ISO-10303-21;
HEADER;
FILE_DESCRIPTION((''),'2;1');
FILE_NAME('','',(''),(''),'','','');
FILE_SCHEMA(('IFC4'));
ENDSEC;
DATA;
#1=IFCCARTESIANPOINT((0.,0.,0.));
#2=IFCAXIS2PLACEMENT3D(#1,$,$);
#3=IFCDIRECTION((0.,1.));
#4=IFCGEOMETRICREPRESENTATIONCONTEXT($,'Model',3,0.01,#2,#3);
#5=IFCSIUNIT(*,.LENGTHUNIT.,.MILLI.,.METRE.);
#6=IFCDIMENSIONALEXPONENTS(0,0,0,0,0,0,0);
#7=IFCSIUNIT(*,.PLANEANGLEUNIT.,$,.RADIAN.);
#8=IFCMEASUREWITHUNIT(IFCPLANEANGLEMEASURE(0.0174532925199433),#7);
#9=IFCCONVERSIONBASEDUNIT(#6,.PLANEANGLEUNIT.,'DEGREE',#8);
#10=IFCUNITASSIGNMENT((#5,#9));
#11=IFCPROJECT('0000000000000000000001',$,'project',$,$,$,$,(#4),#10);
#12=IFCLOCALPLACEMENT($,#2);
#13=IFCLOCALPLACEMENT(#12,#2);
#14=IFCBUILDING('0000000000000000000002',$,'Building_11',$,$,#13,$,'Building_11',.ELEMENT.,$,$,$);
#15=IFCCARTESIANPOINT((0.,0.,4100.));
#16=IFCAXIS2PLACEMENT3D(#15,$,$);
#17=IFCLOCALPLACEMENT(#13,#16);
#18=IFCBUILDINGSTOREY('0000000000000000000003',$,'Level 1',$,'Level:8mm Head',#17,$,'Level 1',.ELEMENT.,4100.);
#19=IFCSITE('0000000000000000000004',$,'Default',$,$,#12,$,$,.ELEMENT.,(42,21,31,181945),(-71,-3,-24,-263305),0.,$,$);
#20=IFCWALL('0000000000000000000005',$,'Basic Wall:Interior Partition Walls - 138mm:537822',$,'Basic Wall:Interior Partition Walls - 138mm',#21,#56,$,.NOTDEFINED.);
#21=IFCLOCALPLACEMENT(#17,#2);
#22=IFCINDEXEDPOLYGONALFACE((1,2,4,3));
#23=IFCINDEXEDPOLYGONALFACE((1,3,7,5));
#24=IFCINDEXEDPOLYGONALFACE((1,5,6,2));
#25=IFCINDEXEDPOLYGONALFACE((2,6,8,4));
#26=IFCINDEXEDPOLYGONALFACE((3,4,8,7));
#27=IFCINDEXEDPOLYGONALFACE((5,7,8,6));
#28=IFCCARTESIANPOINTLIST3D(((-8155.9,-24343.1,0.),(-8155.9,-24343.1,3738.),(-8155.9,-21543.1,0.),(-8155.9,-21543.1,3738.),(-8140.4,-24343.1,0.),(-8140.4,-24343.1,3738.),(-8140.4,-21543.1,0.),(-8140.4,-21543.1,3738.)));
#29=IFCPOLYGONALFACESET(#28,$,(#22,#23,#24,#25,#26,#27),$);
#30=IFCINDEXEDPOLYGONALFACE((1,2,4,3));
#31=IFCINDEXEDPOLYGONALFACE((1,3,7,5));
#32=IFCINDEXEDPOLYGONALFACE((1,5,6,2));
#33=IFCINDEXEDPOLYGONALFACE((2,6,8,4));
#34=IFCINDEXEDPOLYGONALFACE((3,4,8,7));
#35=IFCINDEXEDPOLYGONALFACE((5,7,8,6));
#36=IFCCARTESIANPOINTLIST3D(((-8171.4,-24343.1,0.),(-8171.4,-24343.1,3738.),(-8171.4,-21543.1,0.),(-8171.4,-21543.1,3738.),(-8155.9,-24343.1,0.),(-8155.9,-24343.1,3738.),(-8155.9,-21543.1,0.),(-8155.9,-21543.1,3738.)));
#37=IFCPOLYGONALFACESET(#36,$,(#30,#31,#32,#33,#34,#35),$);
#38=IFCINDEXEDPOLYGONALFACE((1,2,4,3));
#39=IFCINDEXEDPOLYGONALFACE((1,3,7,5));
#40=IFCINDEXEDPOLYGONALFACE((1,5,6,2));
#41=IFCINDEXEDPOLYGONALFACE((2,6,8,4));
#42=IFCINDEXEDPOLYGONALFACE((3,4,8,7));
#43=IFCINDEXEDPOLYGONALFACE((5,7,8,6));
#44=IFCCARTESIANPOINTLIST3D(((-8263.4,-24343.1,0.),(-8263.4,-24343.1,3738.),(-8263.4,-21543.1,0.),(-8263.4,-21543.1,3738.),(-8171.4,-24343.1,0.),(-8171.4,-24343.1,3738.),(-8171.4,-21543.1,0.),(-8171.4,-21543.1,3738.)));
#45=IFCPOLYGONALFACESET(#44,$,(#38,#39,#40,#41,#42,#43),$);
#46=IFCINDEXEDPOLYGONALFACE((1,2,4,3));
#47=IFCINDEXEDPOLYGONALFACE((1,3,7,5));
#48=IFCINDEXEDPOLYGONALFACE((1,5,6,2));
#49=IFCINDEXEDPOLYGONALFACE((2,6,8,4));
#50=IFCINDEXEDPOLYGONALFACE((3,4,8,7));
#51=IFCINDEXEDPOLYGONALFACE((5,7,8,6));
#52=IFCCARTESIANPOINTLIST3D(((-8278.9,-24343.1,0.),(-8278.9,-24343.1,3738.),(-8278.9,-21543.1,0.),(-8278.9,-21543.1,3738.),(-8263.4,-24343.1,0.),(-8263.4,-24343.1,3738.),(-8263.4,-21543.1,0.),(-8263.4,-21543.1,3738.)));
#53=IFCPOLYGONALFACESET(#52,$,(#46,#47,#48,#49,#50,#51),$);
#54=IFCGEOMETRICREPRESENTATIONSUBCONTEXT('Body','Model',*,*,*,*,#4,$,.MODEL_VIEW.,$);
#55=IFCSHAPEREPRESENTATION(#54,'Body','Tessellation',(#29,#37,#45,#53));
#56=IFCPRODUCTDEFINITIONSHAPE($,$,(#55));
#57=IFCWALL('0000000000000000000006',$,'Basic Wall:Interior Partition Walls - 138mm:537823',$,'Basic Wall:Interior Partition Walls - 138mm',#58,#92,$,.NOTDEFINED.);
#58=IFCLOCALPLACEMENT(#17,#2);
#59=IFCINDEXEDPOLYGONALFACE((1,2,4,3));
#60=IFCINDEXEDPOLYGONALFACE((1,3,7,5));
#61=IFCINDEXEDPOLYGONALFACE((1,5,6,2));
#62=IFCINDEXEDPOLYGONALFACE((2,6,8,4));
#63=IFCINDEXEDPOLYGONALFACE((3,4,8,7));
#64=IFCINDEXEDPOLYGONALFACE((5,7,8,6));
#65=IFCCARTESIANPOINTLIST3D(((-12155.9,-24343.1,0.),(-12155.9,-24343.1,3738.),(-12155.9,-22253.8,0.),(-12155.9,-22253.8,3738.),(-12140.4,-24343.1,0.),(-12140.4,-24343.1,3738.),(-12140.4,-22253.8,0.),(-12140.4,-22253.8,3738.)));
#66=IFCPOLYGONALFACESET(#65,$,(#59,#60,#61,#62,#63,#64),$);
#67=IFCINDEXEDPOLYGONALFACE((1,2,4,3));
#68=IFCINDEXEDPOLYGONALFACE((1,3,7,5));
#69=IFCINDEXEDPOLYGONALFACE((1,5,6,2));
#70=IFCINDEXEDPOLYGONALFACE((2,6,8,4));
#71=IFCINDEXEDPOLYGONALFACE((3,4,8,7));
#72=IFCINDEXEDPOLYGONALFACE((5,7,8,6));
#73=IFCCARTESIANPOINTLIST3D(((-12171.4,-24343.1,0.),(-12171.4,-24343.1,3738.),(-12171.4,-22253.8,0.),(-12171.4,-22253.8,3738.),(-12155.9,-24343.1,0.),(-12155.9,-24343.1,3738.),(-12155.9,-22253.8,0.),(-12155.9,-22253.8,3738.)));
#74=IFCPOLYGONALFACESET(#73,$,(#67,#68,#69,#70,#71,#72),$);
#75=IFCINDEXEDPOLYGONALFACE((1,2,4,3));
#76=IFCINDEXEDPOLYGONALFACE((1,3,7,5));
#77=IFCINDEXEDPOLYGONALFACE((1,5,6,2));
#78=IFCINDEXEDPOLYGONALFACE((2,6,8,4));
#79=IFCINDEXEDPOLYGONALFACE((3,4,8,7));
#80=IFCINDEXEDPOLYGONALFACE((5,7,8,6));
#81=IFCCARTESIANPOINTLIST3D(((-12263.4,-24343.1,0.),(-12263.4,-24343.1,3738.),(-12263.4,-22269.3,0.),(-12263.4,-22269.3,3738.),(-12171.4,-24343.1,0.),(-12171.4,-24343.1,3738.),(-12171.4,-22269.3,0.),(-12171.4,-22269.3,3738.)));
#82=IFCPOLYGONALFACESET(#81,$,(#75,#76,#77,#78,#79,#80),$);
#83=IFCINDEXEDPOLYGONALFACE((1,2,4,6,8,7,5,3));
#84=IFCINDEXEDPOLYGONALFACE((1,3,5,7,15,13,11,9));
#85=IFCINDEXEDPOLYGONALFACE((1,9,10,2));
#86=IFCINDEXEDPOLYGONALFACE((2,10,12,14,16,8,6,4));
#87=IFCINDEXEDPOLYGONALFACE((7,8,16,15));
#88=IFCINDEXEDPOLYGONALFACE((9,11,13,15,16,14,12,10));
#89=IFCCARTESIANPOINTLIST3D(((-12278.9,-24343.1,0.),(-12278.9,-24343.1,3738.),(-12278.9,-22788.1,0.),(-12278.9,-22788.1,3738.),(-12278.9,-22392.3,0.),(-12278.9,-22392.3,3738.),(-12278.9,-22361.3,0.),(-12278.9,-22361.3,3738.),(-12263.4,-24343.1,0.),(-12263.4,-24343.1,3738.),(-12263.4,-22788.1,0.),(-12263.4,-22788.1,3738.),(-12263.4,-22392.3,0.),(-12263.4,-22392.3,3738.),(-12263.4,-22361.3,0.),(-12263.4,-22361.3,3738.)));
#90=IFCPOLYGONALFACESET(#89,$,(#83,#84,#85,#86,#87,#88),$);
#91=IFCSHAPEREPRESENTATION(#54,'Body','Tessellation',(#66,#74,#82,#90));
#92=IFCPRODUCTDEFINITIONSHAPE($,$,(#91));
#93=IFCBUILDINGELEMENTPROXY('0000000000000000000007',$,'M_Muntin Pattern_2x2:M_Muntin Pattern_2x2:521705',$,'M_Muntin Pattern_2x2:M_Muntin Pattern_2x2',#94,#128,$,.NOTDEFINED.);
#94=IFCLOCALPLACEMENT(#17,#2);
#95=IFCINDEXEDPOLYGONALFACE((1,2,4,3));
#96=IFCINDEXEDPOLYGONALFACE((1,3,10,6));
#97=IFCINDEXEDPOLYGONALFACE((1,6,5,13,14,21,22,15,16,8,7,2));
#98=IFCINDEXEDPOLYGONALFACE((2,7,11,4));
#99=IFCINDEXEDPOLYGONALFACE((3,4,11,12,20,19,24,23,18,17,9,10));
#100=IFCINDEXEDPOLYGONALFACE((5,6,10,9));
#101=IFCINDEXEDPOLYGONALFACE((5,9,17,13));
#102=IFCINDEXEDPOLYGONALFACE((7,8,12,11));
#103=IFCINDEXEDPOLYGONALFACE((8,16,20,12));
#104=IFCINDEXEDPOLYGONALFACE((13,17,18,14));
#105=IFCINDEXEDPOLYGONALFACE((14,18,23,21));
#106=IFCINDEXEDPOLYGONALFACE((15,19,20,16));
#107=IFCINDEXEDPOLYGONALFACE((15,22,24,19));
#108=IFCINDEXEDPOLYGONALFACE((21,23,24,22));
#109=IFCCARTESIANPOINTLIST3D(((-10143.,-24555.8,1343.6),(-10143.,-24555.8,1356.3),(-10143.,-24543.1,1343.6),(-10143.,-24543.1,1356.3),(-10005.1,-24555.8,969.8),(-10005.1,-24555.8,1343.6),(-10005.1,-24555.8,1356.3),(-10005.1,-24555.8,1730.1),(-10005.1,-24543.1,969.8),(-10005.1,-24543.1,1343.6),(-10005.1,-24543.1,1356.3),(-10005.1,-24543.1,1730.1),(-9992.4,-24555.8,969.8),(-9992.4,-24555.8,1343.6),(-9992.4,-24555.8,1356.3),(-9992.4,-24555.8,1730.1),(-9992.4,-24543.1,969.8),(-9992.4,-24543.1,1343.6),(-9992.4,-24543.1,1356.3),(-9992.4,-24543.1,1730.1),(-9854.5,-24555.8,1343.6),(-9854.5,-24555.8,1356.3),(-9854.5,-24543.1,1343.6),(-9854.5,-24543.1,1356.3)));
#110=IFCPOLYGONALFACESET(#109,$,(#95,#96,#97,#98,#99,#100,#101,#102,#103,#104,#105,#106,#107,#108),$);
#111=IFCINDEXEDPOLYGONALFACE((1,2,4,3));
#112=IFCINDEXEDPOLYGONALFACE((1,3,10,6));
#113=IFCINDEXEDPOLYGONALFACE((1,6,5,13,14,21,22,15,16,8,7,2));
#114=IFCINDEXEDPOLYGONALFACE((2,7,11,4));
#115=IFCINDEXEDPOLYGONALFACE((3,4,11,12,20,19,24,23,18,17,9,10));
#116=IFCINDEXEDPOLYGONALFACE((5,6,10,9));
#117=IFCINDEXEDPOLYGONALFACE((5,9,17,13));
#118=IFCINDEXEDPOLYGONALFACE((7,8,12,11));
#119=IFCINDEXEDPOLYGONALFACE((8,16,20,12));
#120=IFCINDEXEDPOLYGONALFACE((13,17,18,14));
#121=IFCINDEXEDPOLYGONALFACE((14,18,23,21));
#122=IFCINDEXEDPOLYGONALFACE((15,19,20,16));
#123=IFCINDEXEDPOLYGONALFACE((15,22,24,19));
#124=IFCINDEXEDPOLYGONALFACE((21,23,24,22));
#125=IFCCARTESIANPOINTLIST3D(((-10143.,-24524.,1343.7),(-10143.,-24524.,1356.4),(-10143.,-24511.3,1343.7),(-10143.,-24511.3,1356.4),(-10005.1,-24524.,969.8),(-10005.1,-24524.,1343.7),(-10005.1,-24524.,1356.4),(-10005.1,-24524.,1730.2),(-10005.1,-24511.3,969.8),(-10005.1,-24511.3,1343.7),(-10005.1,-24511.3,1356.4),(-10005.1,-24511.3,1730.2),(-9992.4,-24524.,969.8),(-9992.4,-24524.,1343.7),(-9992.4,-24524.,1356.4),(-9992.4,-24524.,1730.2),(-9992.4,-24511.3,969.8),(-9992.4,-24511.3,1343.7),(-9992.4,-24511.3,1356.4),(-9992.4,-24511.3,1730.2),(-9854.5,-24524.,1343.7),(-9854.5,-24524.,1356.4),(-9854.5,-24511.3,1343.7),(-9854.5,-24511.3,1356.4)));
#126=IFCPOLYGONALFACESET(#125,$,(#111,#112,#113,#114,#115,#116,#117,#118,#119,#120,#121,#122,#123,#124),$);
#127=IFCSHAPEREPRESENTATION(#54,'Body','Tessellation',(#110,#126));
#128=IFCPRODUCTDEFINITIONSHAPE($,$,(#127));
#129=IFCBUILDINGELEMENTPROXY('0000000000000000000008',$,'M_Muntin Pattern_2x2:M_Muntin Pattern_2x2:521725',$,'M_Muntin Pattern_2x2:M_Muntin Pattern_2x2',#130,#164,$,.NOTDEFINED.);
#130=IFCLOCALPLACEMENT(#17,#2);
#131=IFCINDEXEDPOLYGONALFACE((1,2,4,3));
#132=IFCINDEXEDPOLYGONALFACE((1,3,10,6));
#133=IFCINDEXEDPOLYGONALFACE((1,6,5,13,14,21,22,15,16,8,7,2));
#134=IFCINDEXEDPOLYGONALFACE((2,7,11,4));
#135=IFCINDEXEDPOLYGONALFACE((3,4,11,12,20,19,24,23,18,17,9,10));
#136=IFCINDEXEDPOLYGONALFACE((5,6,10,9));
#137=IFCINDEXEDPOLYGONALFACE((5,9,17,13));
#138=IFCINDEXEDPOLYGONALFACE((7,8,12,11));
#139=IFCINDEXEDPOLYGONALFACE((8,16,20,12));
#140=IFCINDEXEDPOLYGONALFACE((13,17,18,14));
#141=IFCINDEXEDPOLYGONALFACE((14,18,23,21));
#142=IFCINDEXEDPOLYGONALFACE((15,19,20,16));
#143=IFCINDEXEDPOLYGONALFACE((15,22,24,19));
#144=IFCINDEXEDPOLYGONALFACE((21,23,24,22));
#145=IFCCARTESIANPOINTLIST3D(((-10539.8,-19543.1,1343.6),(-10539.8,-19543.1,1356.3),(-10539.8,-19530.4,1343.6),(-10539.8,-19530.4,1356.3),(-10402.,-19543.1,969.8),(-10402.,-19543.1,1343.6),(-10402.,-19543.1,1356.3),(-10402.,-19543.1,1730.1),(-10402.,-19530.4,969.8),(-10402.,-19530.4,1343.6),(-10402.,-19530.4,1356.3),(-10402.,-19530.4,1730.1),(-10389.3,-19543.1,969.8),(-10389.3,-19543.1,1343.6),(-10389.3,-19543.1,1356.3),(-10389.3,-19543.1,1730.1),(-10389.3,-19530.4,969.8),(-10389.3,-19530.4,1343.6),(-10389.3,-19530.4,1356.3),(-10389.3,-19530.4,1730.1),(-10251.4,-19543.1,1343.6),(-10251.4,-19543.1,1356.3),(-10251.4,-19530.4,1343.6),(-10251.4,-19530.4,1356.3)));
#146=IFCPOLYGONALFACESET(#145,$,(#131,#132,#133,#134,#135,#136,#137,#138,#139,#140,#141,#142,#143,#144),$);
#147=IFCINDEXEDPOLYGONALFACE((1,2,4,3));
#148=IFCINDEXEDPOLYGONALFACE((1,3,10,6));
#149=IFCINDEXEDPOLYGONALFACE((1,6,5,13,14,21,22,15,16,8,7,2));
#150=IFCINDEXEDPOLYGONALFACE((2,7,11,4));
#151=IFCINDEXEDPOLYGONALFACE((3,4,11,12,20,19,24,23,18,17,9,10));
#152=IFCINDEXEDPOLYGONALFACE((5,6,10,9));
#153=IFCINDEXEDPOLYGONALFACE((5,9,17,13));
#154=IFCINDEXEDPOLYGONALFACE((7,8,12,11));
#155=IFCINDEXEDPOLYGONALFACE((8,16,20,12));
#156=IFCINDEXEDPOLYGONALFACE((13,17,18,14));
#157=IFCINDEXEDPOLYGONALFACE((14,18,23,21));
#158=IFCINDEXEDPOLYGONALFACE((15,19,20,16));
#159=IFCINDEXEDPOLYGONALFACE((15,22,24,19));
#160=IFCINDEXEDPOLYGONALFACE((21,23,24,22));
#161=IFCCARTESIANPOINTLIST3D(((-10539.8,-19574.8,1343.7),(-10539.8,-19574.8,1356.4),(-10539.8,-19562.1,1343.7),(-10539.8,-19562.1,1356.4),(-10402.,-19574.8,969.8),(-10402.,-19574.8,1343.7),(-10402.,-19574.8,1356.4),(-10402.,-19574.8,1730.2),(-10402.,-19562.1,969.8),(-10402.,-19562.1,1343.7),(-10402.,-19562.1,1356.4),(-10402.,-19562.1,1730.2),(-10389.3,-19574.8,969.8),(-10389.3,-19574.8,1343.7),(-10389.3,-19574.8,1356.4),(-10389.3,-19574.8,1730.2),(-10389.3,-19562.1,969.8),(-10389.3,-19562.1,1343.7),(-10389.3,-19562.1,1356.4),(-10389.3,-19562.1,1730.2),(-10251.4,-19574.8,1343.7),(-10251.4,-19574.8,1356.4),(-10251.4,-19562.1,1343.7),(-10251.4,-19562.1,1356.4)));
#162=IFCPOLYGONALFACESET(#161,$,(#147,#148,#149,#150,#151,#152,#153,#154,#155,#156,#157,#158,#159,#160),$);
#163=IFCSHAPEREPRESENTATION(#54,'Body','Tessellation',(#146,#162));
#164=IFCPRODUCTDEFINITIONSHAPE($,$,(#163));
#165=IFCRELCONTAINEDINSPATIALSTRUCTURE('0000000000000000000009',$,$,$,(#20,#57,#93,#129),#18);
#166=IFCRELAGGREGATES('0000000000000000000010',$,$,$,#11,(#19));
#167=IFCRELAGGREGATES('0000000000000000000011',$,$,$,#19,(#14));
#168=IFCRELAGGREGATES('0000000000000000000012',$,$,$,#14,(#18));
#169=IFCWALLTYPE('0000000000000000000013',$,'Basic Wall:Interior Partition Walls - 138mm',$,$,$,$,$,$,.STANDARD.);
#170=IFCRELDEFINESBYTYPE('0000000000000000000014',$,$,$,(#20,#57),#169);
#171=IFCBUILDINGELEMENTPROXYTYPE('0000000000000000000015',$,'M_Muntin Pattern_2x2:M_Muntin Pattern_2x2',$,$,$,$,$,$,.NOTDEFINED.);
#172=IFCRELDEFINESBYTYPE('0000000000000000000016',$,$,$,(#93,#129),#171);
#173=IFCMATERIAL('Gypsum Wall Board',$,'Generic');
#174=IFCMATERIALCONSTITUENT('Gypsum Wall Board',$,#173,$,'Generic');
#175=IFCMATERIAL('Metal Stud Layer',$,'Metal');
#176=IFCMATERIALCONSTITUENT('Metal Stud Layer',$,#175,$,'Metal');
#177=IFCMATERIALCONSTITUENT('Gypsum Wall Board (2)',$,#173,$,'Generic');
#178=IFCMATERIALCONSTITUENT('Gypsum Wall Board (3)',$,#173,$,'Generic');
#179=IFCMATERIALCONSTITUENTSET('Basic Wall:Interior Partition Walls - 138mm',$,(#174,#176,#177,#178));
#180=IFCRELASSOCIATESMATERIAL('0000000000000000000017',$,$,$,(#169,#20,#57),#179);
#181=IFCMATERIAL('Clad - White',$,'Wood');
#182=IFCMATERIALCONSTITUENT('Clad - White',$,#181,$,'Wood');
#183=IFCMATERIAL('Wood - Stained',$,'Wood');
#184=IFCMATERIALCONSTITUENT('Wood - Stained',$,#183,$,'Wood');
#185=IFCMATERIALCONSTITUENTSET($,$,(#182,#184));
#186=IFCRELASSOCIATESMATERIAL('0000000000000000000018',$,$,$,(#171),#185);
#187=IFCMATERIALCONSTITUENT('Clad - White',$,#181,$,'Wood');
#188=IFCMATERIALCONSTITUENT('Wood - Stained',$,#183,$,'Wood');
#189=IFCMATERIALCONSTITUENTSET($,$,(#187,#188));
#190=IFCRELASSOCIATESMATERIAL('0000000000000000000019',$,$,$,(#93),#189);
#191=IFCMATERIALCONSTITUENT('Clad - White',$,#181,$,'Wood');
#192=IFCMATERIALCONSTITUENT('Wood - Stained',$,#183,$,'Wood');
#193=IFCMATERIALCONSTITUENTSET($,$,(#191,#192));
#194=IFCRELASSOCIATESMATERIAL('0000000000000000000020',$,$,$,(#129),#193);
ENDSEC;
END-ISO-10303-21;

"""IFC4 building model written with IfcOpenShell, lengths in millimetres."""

from ifc_helpers import new_model, entity, si_unit, converted_unit, direction, frame, origin, place, context, subcontext, project, spatial, indexed_curve, outline, extrude, source, transform, mapped, material, constituent, constituent_set, type_object, type_shapes, element, save


model = new_model("IFC4")

# Units and contexts
model_context = context("Model", 3, precision=0.01, world=origin(), true_north=direction((0.0, 1.0)))
body_context = subcontext(model_context, "Body", "Model", "MODEL_VIEW")
ifc_project = project(units=[si_unit("LENGTHUNIT", "METRE", prefix="MILLI"), converted_unit("PLANEANGLEUNIT", "DEGREE", entity("IfcPlaneAngleMeasure", 0.0174532925199433), si_unit("PLANEANGLEUNIT", "RADIAN"), dimensions=[0, 0, 0, 0, 0, 0, 0])], contexts=[model_context])

# Site, building, storey
site_placement = place(None, origin())
site = spatial("IfcSite", under=ifc_project, at=site_placement, Name="Default", CompositionType="ELEMENT", RefLatitude=(42, 21, 31, 181945), RefLongitude=(-71, -3, -24, -263305), RefElevation=0.0)
building_placement = place(site_placement, origin())
building = spatial("IfcBuilding", under=site, at=building_placement, Name="Building_11", LongName="Building_11", CompositionType="ELEMENT")
storey_placement = place(building_placement, frame((0.0, 0.0, 4100.0)))
storey = spatial("IfcBuildingStorey", under=building, at=storey_placement, Name="Level 1", ObjectType="Level:8mm Head", LongName="Level 1", CompositionType="ELEMENT", Elevation=4100.0)

# Walls
ifc_material_1 = material(Name="Gypsum Wall Board", Category="Generic")
ifc_constituent_1 = constituent(ifc_material_1, Name="Gypsum Wall Board", Category="Generic")
ifc_material_2 = material(Name="Metal Stud Layer", Category="Metal")
ifc_constituent_2 = constituent(ifc_material_2, Name="Metal Stud Layer", Category="Metal")
ifc_constituent_3 = constituent(ifc_material_1, Name="Gypsum Wall Board (2)", Category="Generic")
ifc_constituent_4 = constituent(ifc_material_1, Name="Gypsum Wall Board (3)", Category="Generic")
ifc_constituent_set_1 = constituent_set(constituents=[ifc_constituent_1, ifc_constituent_2, ifc_constituent_3, ifc_constituent_4], Name="Basic Wall:Interior Partition Walls - 138mm")
wall_type_1 = type_object("IfcWallType", Name="Basic Wall:Interior Partition Walls - 138mm", PredefinedType="STANDARD", material=ifc_constituent_set_1)
wall_1_placement = place(storey_placement, frame((-8209.7, -24343.1, 0.0), z_axis=(0.0, 0.0, 1.0), x_axis=(0.0, 1.0, 0.0)))
element("IfcWall", 1, at=wall_1_placement, inside=storey, type_object=wall_type_1, material=ifc_constituent_set_1, Name="Basic Wall:Interior Partition Walls - 138mm:537822", ObjectType="Basic Wall:Interior Partition Walls - 138mm", PredefinedType="NOTDEFINED", context=body_context, shape_type="SweptSolid", body=[
    extrude(outline(indexed_curve([(-1869.0, -1400.0), (1869.0, -1400.0), (1869.0, 1400.0), (-1869.0, 1400.0), (-1869.0, -1400.0)], self_intersect=False)), frame((1400.0, -53.7, 1869.0), z_axis=(0.0, -1.0, 0.0), x_axis=(0.0, 0.0, 1.0)), (0.0, 0.0, 1.0), 15.5),
    extrude(outline(indexed_curve([(-1869.0, -1400.0), (1869.0, -1400.0), (1869.0, 1400.0), (-1869.0, 1400.0), (-1869.0, -1400.0)], self_intersect=False)), frame((1400.0, -38.2, 1869.0), z_axis=(0.0, -1.0, 0.0), x_axis=(0.0, 0.0, 1.0)), (0.0, 0.0, 1.0), 15.5),
    extrude(outline(indexed_curve([(-1869.0, -1400.0), (1869.0, -1400.0), (1869.0, 1400.0), (-1869.0, 1400.0), (-1869.0, -1400.0)], self_intersect=False)), frame((1400.0, 53.8, 1869.0), z_axis=(0.0, -1.0, 0.0), x_axis=(0.0, 0.0, 1.0)), (0.0, 0.0, 1.0), 92.0),
    extrude(outline(indexed_curve([(-1400.0, -1869.0), (1400.0, -1869.0), (1400.0, 1869.0), (-1400.0, 1869.0), (-1400.0, -1869.0)], self_intersect=False)), frame((1400.0, 69.3, 1869.0), z_axis=(0.0, -1.0, 0.0), x_axis=(1.0, 0.0, 0.0)), (0.0, 0.0, 1.0), 15.5),
])
wall_2_placement = place(storey_placement, frame((-12209.7, -24343.1, 0.0), z_axis=(0.0, 0.0, 1.0), x_axis=(0.0, 1.0, 0.0)))
element("IfcWall", 2, at=wall_2_placement, inside=storey, type_object=wall_type_1, material=ifc_constituent_set_1, Name="Basic Wall:Interior Partition Walls - 138mm:537823", ObjectType="Basic Wall:Interior Partition Walls - 138mm", PredefinedType="NOTDEFINED", context=body_context, shape_type="SweptSolid", body=[
    extrude(outline(indexed_curve([(-1869.0, -1044.6), (1869.0, -1044.6), (1869.0, 1044.6), (-1869.0, 1044.6), (-1869.0, -1044.6)], self_intersect=False)), frame((1044.6, -53.8, 1869.0), z_axis=(0.0, -1.0, 0.0), x_axis=(0.0, 0.0, 1.0)), (0.0, 0.0, 1.0), 15.5),
    extrude(outline(indexed_curve([(-1869.0, -1044.6), (1869.0, -1044.6), (1869.0, 1044.6), (-1869.0, 1044.6), (-1869.0, -1044.6)], self_intersect=False)), frame((1044.6, -38.2, 1869.0), z_axis=(0.0, -1.0, 0.0), x_axis=(0.0, 0.0, 1.0)), (0.0, 0.0, 1.0), 15.5),
    extrude(outline(indexed_curve([(-1869.0, -1036.9), (1869.0, -1036.9), (1869.0, 1036.9), (-1869.0, 1036.9), (-1869.0, -1036.9)], self_intersect=False)), frame((1036.9, 53.8, 1869.0), z_axis=(0.0, -1.0, 0.0), x_axis=(0.0, 0.0, 1.0)), (0.0, 0.0, 1.0), 92.0),
    extrude(outline(indexed_curve([(-1371.9, -1869.0), (183.1, -1869.0), (578.9, -1869.0), (609.9, -1869.0), (609.9, 1869.0), (578.9, 1869.0), (183.1, 1869.0), (-1371.9, 1869.0), (-1371.9, -1869.0)], self_intersect=False)), frame((1371.9, 69.2, 1869.0), z_axis=(0.0, -1.0, 0.0), x_axis=(1.0, 0.0, 0.0)), (0.0, 0.0, 1.0), 15.5),
])

# Building element proxies
ifc_material_3 = material(Name="Clad - White", Category="Wood")
ifc_constituent_5 = constituent(ifc_material_3, Name="Clad - White", Category="Wood")
ifc_material_4 = material(Name="Wood - Stained", Category="Wood")
ifc_constituent_6 = constituent(ifc_material_4, Name="Wood - Stained", Category="Wood")
ifc_constituent_set_2 = constituent_set(constituents=[ifc_constituent_5, ifc_constituent_6])
ifc_constituent_7 = constituent(ifc_material_3, Name="Clad - White", Category="Wood")
ifc_constituent_8 = constituent(ifc_material_4, Name="Wood - Stained", Category="Wood")
ifc_constituent_set_3 = constituent_set(constituents=[ifc_constituent_7, ifc_constituent_8])
building_element_proxy_type_1 = type_object("IfcBuildingElementProxyType", Name="M_Muntin Pattern_2x2:M_Muntin Pattern_2x2", PredefinedType="NOTDEFINED", material=ifc_constituent_set_3)
shared_shape_1 = source(origin(), body_context, "Body", "SweptSolid", [
    extrude(outline(indexed_curve([(6.4, -6.4), (380.1, -6.4), (380.1, 6.3), (6.4, 6.3), (6.4, 144.2), (-6.3, 144.2), (-6.3, 6.3), (-380.2, 6.3), (-380.2, -6.4), (-6.3, -6.4), (-6.3, -144.2), (6.4, -144.2), (6.4, -6.4)], self_intersect=False)), frame((0.0, 9.5, 380.1), z_axis=(0.0, 1.0, 0.0), x_axis=(0.0, 0.0, 1.0)), (0.0, 0.0, 1.0), 12.7),
    extrude(outline(indexed_curve([(6.4, -6.4), (380.2, -6.4), (380.2, 6.3), (6.4, 6.3), (6.4, 144.2), (-6.3, 144.2), (-6.3, 6.3), (-380.2, 6.3), (-380.2, -6.4), (-6.3, -6.4), (-6.3, -144.2), (6.4, -144.2), (6.4, -6.4)], self_intersect=False)), frame((0.0, -22.2, 380.2), z_axis=(0.0, 1.0, 0.0), x_axis=(0.0, 0.0, 1.0)), (0.0, 0.0, 1.0), 12.7),
])
type_shapes(building_element_proxy_type_1, [shared_shape_1])
proxy_1_placement = place(storey_placement, frame((-9998.8, -24533.6, 969.8), z_axis=(0.0, 0.0, 1.0), x_axis=(-1.0, 0.0, 0.0)))
element("IfcBuildingElementProxy", 3, at=proxy_1_placement, inside=storey, type_object=building_element_proxy_type_1, material=ifc_constituent_set_2, Name="M_Muntin Pattern_2x2:M_Muntin Pattern_2x2:521705", ObjectType="M_Muntin Pattern_2x2:M_Muntin Pattern_2x2", PredefinedType="NOTDEFINED", context=body_context, shape_type="MappedRepresentation", body=[
    mapped(shared_shape_1, transform((0.0, 0.0, 0.0), scale=1.0)),
])
ifc_constituent_9 = constituent(ifc_material_3, Name="Clad - White", Category="Wood")
ifc_constituent_10 = constituent(ifc_material_4, Name="Wood - Stained", Category="Wood")
ifc_constituent_set_4 = constituent_set(constituents=[ifc_constituent_9, ifc_constituent_10])
proxy_2_placement = place(storey_placement, frame((-10395.6, -19552.6, 969.8)))
element("IfcBuildingElementProxy", 4, at=proxy_2_placement, inside=storey, type_object=building_element_proxy_type_1, material=ifc_constituent_set_4, Name="M_Muntin Pattern_2x2:M_Muntin Pattern_2x2:521725", ObjectType="M_Muntin Pattern_2x2:M_Muntin Pattern_2x2", PredefinedType="NOTDEFINED", context=body_context, shape_type="MappedRepresentation", body=[
    mapped(shared_shape_1, transform((0.0, 0.0, 0.0), scale=1.0)),
])

save(model, "model.ifc")
